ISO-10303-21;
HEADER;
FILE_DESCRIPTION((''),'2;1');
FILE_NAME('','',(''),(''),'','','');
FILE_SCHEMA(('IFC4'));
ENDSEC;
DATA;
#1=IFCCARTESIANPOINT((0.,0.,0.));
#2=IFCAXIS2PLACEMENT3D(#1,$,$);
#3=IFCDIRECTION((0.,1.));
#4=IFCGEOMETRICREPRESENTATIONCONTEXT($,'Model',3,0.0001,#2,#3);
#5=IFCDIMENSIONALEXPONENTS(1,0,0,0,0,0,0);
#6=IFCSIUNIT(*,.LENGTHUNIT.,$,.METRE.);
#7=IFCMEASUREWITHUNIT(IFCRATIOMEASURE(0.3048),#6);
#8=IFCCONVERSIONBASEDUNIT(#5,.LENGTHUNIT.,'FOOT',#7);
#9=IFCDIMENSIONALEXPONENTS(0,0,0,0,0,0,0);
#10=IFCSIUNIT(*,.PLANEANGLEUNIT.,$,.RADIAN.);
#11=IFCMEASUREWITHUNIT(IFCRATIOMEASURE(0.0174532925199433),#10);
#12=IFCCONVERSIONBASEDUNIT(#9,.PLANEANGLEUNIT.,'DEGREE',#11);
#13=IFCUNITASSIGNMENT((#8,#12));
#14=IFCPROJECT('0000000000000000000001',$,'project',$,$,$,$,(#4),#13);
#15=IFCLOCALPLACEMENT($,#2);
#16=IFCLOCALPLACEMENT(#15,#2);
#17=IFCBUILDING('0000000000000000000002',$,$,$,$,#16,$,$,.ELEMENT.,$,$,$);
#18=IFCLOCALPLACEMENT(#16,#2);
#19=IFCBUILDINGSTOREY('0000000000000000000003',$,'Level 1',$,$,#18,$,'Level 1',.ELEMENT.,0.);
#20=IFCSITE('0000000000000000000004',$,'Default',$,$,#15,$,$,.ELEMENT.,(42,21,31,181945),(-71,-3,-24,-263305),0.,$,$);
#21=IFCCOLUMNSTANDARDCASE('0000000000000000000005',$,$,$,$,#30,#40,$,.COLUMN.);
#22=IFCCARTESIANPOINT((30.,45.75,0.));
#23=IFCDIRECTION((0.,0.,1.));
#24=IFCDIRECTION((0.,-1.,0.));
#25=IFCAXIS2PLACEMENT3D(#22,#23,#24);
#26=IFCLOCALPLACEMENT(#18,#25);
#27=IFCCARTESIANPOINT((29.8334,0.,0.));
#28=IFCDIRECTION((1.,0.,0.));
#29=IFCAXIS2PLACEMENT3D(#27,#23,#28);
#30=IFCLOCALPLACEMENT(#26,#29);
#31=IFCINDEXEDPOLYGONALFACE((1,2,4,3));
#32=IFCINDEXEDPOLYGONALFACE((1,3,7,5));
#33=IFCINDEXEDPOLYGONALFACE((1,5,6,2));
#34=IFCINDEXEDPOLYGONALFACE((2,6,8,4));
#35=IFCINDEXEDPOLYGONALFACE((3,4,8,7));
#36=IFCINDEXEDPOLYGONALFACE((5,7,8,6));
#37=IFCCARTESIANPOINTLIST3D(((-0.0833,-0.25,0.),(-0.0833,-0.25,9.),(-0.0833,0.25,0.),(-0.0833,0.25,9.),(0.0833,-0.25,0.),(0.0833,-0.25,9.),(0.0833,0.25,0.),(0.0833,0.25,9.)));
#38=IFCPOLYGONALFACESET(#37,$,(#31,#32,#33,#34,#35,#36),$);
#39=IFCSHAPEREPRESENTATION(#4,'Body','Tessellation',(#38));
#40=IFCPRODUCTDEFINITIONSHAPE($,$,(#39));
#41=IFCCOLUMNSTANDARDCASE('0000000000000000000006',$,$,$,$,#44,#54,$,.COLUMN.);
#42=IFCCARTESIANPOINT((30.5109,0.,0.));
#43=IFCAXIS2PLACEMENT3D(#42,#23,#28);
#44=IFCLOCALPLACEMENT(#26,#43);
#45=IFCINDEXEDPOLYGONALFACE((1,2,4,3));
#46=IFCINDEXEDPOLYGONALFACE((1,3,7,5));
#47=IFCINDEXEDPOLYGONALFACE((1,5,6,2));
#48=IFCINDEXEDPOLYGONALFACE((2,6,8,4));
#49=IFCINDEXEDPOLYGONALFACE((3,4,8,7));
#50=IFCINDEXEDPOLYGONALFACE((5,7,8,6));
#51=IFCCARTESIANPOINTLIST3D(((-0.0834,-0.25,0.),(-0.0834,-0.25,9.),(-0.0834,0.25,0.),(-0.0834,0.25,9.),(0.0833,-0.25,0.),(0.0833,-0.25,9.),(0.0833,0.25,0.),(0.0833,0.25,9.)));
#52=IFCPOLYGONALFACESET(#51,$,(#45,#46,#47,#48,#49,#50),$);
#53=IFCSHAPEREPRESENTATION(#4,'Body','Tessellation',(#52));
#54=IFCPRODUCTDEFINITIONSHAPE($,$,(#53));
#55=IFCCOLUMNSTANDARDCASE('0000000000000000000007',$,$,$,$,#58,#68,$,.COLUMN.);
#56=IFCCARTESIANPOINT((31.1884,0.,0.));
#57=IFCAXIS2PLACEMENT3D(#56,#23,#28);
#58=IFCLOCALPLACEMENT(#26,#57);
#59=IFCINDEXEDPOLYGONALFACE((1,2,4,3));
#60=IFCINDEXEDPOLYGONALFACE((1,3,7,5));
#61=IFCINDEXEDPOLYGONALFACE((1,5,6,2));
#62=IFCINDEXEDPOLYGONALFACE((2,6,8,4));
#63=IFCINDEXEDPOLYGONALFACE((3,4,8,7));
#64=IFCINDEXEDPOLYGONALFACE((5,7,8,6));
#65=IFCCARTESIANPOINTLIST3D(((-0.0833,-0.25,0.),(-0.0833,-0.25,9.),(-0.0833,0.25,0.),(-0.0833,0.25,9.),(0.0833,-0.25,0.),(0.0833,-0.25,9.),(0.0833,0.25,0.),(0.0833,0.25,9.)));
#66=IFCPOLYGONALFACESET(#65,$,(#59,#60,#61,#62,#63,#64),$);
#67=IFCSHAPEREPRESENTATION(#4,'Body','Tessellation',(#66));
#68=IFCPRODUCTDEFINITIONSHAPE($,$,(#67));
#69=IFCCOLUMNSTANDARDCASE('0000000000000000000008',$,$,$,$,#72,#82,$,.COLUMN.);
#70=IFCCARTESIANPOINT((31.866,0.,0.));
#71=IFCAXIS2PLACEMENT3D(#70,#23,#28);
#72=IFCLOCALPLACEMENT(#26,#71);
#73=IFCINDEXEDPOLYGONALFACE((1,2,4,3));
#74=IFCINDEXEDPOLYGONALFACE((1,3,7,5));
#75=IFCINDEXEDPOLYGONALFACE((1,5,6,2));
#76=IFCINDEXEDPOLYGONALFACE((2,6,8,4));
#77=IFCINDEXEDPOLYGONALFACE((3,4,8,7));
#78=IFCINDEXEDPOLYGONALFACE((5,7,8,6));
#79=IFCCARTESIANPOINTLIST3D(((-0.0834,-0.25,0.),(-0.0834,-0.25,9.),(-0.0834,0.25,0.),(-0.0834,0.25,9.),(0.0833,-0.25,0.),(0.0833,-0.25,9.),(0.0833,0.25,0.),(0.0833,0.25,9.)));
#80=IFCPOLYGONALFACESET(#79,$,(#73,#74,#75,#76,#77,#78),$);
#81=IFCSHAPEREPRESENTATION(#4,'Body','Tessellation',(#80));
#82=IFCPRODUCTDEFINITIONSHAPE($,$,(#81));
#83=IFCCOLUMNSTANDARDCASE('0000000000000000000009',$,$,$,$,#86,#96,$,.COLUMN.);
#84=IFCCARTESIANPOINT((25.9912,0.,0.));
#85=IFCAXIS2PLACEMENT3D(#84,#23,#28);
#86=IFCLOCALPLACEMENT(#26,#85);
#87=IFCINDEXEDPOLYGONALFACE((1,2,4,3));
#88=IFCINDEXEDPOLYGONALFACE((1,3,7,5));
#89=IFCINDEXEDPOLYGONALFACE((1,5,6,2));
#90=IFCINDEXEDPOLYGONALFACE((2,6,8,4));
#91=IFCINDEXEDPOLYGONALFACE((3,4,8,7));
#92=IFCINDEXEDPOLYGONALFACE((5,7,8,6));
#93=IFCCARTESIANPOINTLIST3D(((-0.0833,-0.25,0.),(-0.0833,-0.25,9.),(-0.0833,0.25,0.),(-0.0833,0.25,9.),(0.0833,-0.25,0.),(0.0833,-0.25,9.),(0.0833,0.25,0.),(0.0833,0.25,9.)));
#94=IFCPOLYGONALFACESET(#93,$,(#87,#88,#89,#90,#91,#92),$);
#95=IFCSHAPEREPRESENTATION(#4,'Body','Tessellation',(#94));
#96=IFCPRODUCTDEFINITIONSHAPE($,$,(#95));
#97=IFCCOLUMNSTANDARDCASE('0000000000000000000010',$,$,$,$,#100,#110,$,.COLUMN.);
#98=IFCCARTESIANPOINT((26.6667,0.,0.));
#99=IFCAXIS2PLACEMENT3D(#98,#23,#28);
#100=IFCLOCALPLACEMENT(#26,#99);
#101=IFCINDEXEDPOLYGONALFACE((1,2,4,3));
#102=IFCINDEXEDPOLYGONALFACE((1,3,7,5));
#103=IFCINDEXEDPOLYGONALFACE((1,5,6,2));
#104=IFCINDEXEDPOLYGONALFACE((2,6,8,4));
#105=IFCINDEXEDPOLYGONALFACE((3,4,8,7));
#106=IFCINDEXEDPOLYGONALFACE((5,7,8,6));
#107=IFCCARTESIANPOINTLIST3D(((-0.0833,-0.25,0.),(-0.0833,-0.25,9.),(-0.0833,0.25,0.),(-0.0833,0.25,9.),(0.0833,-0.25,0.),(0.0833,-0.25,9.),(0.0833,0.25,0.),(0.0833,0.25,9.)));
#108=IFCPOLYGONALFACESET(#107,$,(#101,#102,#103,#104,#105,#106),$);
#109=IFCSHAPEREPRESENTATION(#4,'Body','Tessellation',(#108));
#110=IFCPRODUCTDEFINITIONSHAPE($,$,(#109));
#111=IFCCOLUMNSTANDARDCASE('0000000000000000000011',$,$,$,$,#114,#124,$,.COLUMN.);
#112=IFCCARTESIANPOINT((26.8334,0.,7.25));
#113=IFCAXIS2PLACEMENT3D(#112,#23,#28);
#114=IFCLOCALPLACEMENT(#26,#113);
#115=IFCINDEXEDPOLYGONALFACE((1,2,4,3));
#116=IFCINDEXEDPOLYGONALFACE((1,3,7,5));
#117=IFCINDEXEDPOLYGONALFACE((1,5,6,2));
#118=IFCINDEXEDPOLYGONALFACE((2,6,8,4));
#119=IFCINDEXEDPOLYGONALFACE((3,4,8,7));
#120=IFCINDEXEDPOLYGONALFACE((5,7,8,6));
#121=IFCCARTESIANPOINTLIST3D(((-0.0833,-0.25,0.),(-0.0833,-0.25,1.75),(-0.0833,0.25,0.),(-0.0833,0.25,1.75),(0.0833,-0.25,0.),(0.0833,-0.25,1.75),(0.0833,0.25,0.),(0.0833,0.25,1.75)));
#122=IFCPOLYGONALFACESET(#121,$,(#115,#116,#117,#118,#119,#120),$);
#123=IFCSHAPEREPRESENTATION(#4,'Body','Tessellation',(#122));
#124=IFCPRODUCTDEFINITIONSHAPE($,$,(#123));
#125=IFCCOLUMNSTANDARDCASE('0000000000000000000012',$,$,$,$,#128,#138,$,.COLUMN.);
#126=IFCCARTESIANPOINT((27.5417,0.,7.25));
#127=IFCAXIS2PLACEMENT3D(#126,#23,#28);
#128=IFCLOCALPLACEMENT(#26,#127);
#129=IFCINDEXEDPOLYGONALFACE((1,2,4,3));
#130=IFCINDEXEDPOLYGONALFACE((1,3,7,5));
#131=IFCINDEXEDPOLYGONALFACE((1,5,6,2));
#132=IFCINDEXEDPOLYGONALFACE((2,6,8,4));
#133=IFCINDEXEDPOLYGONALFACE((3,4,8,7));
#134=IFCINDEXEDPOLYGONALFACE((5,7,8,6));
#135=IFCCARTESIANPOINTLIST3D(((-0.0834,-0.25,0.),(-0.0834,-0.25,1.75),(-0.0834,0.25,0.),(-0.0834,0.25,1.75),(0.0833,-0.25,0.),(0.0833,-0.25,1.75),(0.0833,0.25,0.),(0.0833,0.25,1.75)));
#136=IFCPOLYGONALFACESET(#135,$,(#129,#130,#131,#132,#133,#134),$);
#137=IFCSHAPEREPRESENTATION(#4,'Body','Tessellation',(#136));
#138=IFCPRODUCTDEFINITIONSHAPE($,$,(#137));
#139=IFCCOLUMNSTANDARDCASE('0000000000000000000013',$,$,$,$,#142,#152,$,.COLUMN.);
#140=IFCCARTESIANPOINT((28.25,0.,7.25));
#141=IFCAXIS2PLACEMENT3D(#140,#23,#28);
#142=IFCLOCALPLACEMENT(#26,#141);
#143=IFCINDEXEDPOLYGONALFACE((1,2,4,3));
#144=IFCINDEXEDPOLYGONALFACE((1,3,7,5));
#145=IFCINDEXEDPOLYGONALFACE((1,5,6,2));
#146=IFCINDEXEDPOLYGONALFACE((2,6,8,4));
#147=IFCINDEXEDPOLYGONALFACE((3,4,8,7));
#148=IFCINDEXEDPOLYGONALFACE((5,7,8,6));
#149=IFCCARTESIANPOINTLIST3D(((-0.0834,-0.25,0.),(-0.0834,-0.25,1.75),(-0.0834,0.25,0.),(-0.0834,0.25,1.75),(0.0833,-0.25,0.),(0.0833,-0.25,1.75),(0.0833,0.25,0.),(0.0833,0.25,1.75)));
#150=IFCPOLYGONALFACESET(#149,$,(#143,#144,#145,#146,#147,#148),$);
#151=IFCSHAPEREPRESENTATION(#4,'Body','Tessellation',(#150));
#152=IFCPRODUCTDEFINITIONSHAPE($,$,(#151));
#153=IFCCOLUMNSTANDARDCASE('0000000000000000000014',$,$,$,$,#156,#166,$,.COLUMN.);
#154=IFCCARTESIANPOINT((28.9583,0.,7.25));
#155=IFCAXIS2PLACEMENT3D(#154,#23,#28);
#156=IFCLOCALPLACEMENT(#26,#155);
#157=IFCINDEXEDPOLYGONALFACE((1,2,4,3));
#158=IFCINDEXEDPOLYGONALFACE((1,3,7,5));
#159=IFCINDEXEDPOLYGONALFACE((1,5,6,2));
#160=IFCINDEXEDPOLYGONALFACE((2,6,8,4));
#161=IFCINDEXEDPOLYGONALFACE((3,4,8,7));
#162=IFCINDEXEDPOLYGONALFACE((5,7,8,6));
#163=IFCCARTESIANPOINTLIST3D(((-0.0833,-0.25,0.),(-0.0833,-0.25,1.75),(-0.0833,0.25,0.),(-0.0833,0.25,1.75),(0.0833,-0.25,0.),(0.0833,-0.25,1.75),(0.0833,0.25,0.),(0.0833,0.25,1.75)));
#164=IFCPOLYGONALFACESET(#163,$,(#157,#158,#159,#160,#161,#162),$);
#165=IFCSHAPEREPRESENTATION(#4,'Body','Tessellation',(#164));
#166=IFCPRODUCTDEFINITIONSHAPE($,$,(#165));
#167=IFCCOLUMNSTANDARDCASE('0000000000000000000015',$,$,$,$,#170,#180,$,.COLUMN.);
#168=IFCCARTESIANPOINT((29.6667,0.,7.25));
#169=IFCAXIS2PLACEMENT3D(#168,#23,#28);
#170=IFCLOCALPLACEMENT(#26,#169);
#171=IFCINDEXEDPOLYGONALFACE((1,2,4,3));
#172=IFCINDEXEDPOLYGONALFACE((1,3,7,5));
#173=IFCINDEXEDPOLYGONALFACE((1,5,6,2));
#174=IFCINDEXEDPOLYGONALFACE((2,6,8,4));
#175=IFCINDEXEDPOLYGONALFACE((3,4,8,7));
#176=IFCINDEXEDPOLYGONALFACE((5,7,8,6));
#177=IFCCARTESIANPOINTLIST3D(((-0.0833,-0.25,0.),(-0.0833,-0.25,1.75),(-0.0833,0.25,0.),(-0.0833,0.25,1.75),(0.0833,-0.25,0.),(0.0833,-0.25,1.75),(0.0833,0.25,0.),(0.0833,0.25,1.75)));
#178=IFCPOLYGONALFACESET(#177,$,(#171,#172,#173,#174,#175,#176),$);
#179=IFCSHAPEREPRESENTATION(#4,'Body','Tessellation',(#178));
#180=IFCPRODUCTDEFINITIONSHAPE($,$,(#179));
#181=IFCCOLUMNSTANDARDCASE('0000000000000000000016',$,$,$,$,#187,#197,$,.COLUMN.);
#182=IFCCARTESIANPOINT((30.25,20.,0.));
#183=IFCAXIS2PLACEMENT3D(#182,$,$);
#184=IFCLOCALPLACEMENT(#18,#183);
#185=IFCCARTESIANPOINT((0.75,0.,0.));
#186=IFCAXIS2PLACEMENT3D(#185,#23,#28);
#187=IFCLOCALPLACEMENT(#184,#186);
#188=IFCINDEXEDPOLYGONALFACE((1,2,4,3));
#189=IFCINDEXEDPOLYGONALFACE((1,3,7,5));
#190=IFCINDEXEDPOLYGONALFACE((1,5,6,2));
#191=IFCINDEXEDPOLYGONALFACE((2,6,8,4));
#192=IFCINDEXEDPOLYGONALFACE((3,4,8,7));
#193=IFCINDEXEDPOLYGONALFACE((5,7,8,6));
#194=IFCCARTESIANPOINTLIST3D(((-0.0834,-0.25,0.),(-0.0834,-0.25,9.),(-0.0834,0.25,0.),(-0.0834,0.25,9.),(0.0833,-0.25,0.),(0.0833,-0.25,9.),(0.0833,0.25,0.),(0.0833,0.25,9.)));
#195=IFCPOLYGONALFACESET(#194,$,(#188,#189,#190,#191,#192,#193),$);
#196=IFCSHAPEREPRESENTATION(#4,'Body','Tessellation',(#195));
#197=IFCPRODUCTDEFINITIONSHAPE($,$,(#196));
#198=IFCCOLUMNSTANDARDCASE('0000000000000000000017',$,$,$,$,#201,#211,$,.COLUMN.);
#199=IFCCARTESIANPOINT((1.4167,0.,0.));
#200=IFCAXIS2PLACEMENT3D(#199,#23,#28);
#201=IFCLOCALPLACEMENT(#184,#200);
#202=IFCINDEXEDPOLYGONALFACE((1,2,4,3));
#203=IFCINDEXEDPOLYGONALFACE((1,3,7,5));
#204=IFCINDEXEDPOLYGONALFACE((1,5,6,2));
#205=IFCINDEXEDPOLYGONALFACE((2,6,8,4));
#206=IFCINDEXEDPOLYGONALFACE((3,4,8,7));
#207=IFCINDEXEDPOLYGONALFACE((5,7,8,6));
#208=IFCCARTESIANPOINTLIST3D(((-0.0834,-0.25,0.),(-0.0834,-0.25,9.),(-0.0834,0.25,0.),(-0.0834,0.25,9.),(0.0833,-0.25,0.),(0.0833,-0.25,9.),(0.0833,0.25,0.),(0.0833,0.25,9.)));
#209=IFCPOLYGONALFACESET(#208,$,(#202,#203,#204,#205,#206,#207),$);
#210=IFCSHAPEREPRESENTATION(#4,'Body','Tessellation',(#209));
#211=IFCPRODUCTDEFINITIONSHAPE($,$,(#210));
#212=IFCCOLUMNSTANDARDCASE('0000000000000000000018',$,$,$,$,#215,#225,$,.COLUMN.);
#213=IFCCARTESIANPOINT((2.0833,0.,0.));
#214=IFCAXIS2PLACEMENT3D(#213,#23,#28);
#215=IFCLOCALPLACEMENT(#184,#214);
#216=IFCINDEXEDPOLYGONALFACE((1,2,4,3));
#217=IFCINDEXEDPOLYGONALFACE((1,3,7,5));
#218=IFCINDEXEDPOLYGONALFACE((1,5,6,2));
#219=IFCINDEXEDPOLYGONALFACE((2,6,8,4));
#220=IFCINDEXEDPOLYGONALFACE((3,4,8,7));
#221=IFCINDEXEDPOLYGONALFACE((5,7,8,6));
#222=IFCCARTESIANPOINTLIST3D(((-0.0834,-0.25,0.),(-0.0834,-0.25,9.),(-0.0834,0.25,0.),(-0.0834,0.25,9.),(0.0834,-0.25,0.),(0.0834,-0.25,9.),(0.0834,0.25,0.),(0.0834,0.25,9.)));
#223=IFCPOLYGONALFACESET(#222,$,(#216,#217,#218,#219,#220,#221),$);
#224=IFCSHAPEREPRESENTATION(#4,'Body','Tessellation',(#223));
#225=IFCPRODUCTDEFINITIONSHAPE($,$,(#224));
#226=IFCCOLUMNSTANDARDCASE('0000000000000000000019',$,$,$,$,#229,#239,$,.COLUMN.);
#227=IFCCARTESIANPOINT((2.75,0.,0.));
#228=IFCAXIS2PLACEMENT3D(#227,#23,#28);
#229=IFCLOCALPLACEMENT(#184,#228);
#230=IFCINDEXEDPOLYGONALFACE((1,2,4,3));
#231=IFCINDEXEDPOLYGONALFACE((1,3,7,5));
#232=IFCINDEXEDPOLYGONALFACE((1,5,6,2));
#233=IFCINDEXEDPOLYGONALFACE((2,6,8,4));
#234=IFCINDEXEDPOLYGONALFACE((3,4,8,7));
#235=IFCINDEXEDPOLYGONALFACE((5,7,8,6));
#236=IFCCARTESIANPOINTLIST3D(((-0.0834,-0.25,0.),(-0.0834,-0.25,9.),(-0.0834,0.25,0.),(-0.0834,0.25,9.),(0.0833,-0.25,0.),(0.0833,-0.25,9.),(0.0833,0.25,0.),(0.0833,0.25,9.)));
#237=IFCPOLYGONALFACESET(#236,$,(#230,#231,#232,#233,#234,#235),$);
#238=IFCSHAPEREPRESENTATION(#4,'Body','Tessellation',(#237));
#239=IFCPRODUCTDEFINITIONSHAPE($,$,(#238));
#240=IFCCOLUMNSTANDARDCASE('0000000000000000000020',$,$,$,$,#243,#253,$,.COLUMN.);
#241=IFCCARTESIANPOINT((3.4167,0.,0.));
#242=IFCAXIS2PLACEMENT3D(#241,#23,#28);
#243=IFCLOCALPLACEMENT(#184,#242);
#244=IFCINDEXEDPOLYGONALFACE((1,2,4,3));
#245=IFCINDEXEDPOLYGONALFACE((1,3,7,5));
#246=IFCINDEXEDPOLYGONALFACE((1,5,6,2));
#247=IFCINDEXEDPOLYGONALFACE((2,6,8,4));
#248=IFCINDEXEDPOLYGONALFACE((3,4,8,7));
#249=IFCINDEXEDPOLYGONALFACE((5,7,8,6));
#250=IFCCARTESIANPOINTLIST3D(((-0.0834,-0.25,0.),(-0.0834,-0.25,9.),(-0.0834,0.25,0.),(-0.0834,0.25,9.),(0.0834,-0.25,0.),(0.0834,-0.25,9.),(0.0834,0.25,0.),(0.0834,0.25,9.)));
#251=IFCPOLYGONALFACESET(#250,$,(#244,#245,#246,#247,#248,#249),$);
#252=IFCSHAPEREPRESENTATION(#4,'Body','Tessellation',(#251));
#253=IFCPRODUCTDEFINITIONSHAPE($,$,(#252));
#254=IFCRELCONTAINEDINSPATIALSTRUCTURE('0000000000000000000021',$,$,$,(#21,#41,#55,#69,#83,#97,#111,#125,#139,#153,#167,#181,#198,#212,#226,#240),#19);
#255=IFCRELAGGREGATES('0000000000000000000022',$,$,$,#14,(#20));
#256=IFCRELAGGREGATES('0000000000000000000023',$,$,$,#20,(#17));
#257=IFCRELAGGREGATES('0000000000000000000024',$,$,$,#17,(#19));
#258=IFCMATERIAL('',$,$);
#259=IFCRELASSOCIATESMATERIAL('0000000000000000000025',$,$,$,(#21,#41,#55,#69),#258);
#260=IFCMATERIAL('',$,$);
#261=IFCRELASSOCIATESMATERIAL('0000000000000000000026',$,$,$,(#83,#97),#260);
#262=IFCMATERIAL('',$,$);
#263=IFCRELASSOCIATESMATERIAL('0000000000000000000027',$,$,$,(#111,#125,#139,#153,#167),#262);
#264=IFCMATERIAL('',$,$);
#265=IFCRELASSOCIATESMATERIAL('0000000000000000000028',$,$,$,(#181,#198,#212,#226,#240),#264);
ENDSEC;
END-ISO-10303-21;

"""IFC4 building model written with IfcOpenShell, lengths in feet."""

from ifc_helpers import new_model, entity, si_unit, converted_unit, direction, frame, origin, place, context, project, spatial, rectangle, extrude, material, element, save


model = new_model("IFC4")

# Units and contexts
model_context = context("Model", 3, precision=0.0001, world=origin(), true_north=direction((0.0, 1.0)))
ifc_project = project(units=[converted_unit("LENGTHUNIT", "FOOT", entity("IfcRatioMeasure", 0.3048), si_unit("LENGTHUNIT", "METRE"), dimensions=[1, 0, 0, 0, 0, 0, 0]), converted_unit("PLANEANGLEUNIT", "DEGREE", entity("IfcRatioMeasure", 0.0174532925199433), si_unit("PLANEANGLEUNIT", "RADIAN"), dimensions=[0, 0, 0, 0, 0, 0, 0])], contexts=[model_context])

# Site, building, storey
site_placement = place(None, origin())
site = spatial("IfcSite", under=ifc_project, at=site_placement, Name="Default", CompositionType="ELEMENT", RefLatitude=(42, 21, 31, 181945), RefLongitude=(-71, -3, -24, -263305), RefElevation=0.0)
building_placement = place(site_placement, origin())
building = spatial("IfcBuilding", under=site, at=building_placement, CompositionType="ELEMENT")
storey_placement = place(building_placement, origin())
storey = spatial("IfcBuildingStorey", under=building, at=storey_placement, Name="Level 1", LongName="Level 1", CompositionType="ELEMENT", Elevation=0.0)

# Columns
ifc_material_1 = material(Name="")
ifc_material_2 = material(Name="")
placement_1 = place(storey_placement, frame((30.0, 45.75, 0.0), z_axis=(0.0, 0.0, 1.0), x_axis=(0.0, -1.0, 0.0)))
for number, where, z_axis, x_axis in (
    (1, (29.8334, 0.0, 0.0), (0.0, 0.0, 1.0), (1.0, 0.0, 0.0)),
    (2, (30.5109, 0.0, 0.0), (0.0, 0.0, 1.0), (1.0, 0.0, 0.0)),
    (3, (31.1884, 0.0, 0.0), (0.0, 0.0, 1.0), (1.0, 0.0, 0.0)),
    (4, (31.866, 0.0, 0.0), (0.0, 0.0, 1.0), (1.0, 0.0, 0.0)),
):
    element("IfcColumnStandardCase", number, at=place(placement_1, frame(where, z_axis=z_axis, x_axis=x_axis)), inside=storey, material=ifc_material_2, PredefinedType="COLUMN", context=model_context, shape_type="SweptSolid", body=[
        extrude(rectangle(XDim=0.1667, YDim=0.5), origin(), (0.0, 0.0, 1.0), 9.0),
    ])
ifc_material_3 = material(Name="")
for number, where, z_axis, x_axis in (
    (5, (25.9912, 0.0, 0.0), (0.0, 0.0, 1.0), (1.0, 0.0, 0.0)),
    (6, (26.6667, 0.0, 0.0), (0.0, 0.0, 1.0), (1.0, 0.0, 0.0)),
):
    element("IfcColumnStandardCase", number, at=place(placement_1, frame(where, z_axis=z_axis, x_axis=x_axis)), inside=storey, material=ifc_material_3, PredefinedType="COLUMN", context=model_context, shape_type="SweptSolid", body=[
        extrude(rectangle(XDim=0.1667, YDim=0.5), origin(), (0.0, 0.0, 1.0), 9.0),
    ])
ifc_material_4 = material(Name="")
for number, where, z_axis, x_axis in (
    (7, (26.8334, 0.0, 7.25), (0.0, 0.0, 1.0), (1.0, 0.0, 0.0)),
    (8, (27.5417, 0.0, 7.25), (0.0, 0.0, 1.0), (1.0, 0.0, 0.0)),
    (9, (28.25, 0.0, 7.25), (0.0, 0.0, 1.0), (1.0, 0.0, 0.0)),
    (10, (28.9583, 0.0, 7.25), (0.0, 0.0, 1.0), (1.0, 0.0, 0.0)),
    (11, (29.6667, 0.0, 7.25), (0.0, 0.0, 1.0), (1.0, 0.0, 0.0)),
):
    element("IfcColumnStandardCase", number, at=place(placement_1, frame(where, z_axis=z_axis, x_axis=x_axis)), inside=storey, material=ifc_material_4, PredefinedType="COLUMN", context=model_context, shape_type="SweptSolid", body=[
        extrude(rectangle(XDim=0.1667, YDim=0.5), origin(), (0.0, 0.0, 1.0), 1.75),
    ])
wall_placement = place(storey_placement, frame((30.25, 20.0, 0.0)))
for number, where, z_axis, x_axis in (
    (12, (0.75, 0.0, 0.0), (0.0, 0.0, 1.0), (1.0, 0.0, 0.0)),
    (13, (1.4167, 0.0, 0.0), (0.0, 0.0, 1.0), (1.0, 0.0, 0.0)),
    (14, (2.0833, 0.0, 0.0), (0.0, 0.0, 1.0), (1.0, 0.0, 0.0)),
    (15, (2.75, 0.0, 0.0), (0.0, 0.0, 1.0), (1.0, 0.0, 0.0)),
    (16, (3.4167, 0.0, 0.0), (0.0, 0.0, 1.0), (1.0, 0.0, 0.0)),
):
    element("IfcColumnStandardCase", number, at=place(wall_placement, frame(where, z_axis=z_axis, x_axis=x_axis)), inside=storey, material=ifc_material_1, PredefinedType="COLUMN", context=model_context, shape_type="SweptSolid", body=[
        extrude(rectangle(XDim=0.1667, YDim=0.5), origin(), (0.0, 0.0, 1.0), 9.0),
    ])

save(model, "model.ifc")
